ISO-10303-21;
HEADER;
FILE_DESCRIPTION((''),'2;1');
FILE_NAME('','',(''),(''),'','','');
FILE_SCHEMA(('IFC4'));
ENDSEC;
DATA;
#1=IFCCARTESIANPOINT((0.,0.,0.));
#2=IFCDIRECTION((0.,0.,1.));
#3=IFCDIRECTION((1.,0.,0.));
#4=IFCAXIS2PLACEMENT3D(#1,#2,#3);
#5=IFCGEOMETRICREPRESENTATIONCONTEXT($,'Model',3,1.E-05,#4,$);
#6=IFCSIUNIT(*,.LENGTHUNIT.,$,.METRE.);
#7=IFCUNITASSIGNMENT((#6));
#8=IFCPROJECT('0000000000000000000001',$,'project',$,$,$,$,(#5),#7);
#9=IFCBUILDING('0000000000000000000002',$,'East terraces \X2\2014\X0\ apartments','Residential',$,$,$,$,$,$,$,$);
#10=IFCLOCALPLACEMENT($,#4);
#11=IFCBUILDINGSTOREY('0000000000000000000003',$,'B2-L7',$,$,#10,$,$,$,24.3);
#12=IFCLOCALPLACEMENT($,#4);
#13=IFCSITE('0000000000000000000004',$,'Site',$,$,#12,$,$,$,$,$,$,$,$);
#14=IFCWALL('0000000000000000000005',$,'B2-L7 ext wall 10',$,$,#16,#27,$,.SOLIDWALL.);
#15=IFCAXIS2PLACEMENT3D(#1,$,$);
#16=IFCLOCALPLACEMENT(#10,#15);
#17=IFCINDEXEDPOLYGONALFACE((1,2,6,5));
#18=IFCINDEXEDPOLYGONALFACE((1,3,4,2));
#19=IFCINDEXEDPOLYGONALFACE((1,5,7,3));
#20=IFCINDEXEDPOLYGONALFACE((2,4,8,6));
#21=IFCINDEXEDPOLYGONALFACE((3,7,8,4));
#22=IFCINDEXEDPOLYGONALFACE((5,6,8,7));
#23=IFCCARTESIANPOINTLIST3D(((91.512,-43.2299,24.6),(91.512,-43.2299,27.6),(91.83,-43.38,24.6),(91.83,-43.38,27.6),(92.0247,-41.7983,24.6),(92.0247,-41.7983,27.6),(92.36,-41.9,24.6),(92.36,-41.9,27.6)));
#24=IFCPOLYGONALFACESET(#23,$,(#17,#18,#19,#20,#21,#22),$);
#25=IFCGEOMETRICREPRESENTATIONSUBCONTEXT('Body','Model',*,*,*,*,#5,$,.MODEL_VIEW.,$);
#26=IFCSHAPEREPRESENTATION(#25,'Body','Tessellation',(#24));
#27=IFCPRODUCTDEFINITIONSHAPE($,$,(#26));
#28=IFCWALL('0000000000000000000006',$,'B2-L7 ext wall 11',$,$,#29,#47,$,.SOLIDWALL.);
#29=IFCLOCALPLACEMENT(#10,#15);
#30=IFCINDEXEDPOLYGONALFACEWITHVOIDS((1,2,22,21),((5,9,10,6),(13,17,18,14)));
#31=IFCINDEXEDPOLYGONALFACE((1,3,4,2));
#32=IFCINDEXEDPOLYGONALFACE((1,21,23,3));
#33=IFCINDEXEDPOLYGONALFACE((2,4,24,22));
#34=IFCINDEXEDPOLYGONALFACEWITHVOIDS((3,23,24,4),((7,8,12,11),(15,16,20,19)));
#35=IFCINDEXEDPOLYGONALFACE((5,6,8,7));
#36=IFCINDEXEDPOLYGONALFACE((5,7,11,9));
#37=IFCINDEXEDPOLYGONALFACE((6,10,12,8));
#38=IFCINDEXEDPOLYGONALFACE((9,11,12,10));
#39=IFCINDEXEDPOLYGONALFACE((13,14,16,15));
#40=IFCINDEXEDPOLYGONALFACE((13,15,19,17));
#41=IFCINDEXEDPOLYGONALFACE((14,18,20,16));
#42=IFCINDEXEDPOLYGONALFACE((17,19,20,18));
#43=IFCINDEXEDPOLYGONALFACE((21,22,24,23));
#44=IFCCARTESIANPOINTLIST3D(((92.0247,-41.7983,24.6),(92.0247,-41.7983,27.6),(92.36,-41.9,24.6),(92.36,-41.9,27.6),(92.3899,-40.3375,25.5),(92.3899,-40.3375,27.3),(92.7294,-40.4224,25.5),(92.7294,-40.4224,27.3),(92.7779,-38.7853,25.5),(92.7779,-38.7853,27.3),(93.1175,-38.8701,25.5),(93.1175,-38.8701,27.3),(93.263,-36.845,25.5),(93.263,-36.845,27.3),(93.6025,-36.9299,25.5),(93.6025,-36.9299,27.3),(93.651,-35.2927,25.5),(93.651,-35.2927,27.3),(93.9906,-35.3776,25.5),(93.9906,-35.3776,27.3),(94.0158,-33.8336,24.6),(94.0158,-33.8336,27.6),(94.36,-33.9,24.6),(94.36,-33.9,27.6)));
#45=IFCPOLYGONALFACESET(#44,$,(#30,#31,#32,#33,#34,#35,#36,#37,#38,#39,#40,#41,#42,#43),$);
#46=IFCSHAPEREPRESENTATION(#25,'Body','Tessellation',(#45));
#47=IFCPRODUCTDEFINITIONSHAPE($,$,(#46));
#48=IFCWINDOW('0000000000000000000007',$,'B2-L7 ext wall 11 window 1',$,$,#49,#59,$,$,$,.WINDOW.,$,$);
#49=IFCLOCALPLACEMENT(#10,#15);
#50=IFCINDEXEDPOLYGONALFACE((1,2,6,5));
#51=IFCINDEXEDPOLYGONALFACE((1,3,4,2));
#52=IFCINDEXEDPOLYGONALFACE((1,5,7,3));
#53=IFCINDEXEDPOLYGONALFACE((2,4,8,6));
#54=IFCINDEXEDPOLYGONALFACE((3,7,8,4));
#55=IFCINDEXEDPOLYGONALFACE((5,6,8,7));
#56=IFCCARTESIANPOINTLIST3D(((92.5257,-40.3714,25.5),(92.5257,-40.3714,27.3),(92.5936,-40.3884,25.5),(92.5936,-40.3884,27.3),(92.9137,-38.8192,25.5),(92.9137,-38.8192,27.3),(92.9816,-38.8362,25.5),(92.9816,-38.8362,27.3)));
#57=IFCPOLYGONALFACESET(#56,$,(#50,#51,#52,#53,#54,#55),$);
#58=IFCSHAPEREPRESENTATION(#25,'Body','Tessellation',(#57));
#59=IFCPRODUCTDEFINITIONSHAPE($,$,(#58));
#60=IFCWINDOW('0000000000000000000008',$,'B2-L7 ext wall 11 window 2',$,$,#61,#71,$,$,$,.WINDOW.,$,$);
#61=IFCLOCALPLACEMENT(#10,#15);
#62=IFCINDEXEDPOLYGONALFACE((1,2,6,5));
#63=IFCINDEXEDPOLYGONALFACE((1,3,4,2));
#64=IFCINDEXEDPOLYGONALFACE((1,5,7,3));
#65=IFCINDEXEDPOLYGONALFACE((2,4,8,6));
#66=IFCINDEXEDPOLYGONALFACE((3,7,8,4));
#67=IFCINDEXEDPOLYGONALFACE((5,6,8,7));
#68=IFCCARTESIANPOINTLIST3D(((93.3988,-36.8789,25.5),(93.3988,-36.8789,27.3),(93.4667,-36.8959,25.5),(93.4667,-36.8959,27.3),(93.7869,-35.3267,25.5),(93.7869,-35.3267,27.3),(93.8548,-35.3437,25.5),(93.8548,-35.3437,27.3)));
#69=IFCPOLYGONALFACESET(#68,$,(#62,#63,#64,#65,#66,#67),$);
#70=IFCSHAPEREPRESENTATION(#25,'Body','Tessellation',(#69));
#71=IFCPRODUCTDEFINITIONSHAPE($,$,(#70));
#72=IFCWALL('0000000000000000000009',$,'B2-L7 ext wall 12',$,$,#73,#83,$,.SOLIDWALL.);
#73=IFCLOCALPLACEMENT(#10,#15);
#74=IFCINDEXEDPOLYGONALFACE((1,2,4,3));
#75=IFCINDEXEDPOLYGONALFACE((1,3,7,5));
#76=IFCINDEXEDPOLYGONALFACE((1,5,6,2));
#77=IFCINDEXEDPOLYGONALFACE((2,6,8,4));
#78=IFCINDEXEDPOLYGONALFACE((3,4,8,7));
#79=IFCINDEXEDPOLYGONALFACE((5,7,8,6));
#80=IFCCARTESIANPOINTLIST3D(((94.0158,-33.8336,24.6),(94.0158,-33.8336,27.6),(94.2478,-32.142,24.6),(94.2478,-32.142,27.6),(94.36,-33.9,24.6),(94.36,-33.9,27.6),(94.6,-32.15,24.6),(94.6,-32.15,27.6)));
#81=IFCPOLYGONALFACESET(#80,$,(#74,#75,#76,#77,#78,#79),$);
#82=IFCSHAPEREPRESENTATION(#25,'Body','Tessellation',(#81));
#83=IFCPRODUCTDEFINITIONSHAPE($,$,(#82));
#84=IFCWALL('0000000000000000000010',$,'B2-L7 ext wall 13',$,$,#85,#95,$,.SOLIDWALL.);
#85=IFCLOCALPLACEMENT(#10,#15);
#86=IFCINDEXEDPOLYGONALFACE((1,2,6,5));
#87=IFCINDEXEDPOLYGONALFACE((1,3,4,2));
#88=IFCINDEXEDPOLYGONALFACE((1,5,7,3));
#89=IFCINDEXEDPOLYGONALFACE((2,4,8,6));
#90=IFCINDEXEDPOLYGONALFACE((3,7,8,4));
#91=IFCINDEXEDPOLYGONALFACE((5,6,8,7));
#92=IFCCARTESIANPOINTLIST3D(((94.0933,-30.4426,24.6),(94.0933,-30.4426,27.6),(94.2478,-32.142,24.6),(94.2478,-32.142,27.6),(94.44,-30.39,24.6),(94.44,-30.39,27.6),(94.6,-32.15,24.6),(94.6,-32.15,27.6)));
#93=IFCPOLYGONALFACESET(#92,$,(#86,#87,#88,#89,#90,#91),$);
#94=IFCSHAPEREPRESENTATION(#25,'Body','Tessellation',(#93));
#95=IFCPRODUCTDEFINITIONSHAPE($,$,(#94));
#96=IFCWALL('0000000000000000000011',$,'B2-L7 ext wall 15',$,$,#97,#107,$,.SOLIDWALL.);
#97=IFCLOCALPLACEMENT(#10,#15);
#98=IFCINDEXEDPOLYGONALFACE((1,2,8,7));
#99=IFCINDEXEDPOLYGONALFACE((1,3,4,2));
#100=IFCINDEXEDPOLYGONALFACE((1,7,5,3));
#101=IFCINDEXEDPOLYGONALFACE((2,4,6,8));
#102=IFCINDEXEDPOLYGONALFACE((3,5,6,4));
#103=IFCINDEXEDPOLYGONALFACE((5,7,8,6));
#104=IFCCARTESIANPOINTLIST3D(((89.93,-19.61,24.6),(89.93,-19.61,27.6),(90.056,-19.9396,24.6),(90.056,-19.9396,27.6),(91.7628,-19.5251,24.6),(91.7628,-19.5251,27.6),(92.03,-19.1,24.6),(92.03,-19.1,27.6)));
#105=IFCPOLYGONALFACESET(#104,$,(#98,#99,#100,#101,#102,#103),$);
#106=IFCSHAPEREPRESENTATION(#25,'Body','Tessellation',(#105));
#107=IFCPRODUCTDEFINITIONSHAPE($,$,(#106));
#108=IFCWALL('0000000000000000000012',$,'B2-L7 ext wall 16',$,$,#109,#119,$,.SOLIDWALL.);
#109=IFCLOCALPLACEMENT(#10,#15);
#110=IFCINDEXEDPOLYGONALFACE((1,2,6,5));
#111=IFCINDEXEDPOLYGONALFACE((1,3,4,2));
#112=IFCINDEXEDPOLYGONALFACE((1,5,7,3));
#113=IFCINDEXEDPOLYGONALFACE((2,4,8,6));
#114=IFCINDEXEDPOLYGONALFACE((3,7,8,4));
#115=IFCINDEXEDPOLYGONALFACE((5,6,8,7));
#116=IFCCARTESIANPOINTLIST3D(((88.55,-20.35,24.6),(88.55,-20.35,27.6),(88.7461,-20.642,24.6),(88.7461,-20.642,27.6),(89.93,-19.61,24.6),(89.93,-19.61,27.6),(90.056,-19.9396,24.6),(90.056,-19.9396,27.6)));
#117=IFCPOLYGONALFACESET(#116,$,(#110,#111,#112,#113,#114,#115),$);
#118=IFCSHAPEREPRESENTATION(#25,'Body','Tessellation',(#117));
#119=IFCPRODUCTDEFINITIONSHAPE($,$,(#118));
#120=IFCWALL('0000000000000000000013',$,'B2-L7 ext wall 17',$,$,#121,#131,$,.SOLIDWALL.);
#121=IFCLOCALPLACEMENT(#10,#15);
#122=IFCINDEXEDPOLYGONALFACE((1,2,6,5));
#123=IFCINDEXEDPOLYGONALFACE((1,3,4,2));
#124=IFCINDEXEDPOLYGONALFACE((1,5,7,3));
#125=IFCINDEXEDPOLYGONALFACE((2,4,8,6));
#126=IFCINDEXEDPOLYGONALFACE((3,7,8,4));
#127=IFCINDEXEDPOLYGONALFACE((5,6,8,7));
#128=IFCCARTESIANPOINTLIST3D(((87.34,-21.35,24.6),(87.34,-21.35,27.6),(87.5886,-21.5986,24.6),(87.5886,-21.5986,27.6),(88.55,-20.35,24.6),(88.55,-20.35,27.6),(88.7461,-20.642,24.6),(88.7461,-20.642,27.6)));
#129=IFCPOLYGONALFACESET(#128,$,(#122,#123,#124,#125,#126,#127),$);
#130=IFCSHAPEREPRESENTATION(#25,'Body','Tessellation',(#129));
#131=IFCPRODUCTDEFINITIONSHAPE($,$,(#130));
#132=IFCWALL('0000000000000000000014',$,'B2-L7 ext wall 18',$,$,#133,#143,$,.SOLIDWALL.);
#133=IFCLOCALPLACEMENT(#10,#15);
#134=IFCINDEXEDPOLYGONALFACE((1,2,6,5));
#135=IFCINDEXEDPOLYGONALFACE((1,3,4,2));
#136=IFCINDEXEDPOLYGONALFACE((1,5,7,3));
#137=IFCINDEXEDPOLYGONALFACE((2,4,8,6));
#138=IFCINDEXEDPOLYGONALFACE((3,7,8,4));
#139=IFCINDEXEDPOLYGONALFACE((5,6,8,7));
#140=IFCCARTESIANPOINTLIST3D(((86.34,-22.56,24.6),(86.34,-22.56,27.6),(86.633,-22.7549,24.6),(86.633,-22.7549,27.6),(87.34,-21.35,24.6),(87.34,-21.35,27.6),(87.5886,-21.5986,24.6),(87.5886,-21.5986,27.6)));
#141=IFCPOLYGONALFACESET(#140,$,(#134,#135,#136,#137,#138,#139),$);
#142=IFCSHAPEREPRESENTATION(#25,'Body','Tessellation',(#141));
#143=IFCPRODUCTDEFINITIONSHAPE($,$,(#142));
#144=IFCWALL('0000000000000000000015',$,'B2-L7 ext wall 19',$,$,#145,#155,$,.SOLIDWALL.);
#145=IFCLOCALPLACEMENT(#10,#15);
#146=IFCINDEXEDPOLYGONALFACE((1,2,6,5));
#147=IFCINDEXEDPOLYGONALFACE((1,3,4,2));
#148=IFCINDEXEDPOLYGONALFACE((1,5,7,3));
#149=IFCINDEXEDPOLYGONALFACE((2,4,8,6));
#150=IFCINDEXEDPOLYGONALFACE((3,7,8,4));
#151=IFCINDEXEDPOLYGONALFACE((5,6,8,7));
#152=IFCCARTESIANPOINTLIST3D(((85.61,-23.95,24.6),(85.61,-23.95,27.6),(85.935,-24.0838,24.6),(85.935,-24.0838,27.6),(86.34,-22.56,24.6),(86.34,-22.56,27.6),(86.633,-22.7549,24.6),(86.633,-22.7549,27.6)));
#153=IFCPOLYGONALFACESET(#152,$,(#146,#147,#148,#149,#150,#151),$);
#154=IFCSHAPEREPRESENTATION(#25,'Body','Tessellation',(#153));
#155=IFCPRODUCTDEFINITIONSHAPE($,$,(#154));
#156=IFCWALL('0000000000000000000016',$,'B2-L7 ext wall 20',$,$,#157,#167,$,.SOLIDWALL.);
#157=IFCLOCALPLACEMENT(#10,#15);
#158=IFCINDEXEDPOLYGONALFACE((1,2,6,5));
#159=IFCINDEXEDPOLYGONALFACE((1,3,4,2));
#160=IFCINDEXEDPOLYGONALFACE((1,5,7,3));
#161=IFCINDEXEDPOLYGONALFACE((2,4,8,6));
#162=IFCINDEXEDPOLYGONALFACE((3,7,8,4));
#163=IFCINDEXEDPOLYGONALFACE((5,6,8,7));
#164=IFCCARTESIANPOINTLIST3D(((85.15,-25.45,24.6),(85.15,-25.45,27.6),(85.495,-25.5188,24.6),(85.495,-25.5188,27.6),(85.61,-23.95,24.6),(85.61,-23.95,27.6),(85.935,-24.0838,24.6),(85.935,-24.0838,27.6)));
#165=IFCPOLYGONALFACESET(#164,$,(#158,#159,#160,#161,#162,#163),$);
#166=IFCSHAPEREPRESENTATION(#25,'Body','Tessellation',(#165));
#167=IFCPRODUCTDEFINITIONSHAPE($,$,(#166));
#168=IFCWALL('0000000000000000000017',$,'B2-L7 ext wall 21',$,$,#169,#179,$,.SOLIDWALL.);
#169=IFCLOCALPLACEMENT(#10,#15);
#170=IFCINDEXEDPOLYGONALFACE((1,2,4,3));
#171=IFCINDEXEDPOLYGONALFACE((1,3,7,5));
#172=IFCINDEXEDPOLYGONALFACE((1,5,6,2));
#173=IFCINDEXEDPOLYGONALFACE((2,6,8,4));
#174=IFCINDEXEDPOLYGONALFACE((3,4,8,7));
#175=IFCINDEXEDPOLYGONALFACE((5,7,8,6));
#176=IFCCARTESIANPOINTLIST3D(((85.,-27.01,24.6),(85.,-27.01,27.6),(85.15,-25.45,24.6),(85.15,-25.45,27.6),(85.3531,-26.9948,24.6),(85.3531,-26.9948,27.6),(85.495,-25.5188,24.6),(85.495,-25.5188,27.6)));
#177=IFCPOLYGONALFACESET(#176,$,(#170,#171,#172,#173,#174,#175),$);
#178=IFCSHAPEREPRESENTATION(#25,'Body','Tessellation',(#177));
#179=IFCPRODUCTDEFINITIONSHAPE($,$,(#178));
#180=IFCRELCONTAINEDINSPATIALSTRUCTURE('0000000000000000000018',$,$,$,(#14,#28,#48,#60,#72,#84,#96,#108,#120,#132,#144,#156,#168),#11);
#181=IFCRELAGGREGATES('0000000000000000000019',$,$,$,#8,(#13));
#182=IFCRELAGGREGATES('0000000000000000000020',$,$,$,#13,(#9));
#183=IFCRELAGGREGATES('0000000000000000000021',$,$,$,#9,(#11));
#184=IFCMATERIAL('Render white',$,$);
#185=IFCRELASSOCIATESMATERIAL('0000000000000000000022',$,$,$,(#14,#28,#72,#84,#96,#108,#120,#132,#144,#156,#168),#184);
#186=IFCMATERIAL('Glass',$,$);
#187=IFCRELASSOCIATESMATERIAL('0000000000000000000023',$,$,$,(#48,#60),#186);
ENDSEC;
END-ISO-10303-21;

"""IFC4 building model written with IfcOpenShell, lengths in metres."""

from ifc_helpers import new_model, si_unit, frame, origin_with_axes, place, context, subcontext, project, spatial, polyline, outline, extrude, material, element, fill, save


model = new_model("IFC4")

# Units and contexts
model_context = context("Model", 3, precision=1e-05, world=origin_with_axes())
body_context = subcontext(model_context, "Body", "Model", "MODEL_VIEW")
ifc_project = project(units=[si_unit("LENGTHUNIT", "METRE")], contexts=[model_context])

# Site, building, storey
site_placement = place(None, origin_with_axes())
site = spatial("IfcSite", under=ifc_project, at=site_placement, Name="Site")
building = spatial("IfcBuilding", under=site, Name="East terraces — apartments", Description="Residential")
storey_placement = place(None, origin_with_axes())
storey = spatial("IfcBuildingStorey", under=building, at=storey_placement, Name="B2-L7", Elevation=24.3)

# Wall
ifc_material_1 = material(Name="Render white")
wall_1_placement = place(storey_placement, origin_with_axes())
element("IfcWall", 1, at=wall_1_placement, inside=storey, material=ifc_material_1, Name="B2-L7 ext wall 10", PredefinedType="SOLIDWALL", context=body_context, shape_type="SweptSolid", body=[
    extrude(outline(polyline([(91.83, -43.38), (92.36, -41.9), (92.0247, -41.7983), (91.512, -43.2299), (91.83, -43.38)])), frame((0.0, 0.0, 24.6), z_axis=(0.0, 0.0, 1.0), x_axis=(1.0, 0.0, 0.0)), (0.0, 0.0, 1.0), 3.0),
])

# Wall, openings, windows
wall_2_placement = place(storey_placement, origin_with_axes())
wall_2 = element("IfcWall", 2, at=wall_2_placement, inside=storey, material=ifc_material_1, Name="B2-L7 ext wall 11", PredefinedType="SOLIDWALL", context=body_context, shape_type="SweptSolid", body=[
    extrude(outline(polyline([(92.36, -41.9), (94.36, -33.9), (94.0158, -33.8336), (92.0247, -41.7983), (92.36, -41.9)])), frame((0.0, 0.0, 24.6), z_axis=(0.0, 0.0, 1.0), x_axis=(1.0, 0.0, 0.0)), (0.0, 0.0, 1.0), 3.0),
])
opening_1_placement = place(wall_2_placement, origin_with_axes())
opening_1 = element("IfcOpeningElement", 3, at=opening_1_placement, cuts=wall_2, context=body_context, shape_type="SweptSolid", body=[
    extrude(outline(polyline([(92.7779, -40.4345), (93.166, -38.8823), (92.7294, -38.7731), (92.3414, -40.3254), (92.7779, -40.4345)])), frame((0.0, 0.0, 25.5), z_axis=(0.0, 0.0, 1.0), x_axis=(1.0, 0.0, 0.0)), (0.0, 0.0, 1.0), 1.8),
])
opening_2_placement = place(wall_2_placement, origin_with_axes())
opening_2 = element("IfcOpeningElement", 4, at=opening_2_placement, cuts=wall_2, context=body_context, shape_type="SweptSolid", body=[
    extrude(outline(polyline([(93.651, -36.942), (94.0391, -35.3898), (93.6025, -35.2806), (93.2145, -36.8328), (93.651, -36.942)])), frame((0.0, 0.0, 25.5), z_axis=(0.0, 0.0, 1.0), x_axis=(1.0, 0.0, 0.0)), (0.0, 0.0, 1.0), 1.8),
])
ifc_material_2 = material(Name="Glass")
window_1_placement = place(storey_placement, origin_with_axes())
window_1 = element("IfcWindow", 5, at=window_1_placement, inside=storey, material=ifc_material_2, Name="B2-L7 ext wall 11 window 1", PredefinedType="WINDOW", context=body_context, shape_type="SweptSolid", body=[
    extrude(outline(polyline([(92.5936, -40.3884), (92.9816, -38.8362), (92.9137, -38.8192), (92.5257, -40.3714), (92.5936, -40.3884)])), frame((0.0, 0.0, 25.5), z_axis=(0.0, 0.0, 1.0), x_axis=(1.0, 0.0, 0.0)), (0.0, 0.0, 1.0), 1.8),
])
fill(opening_1, window_1)
window_2_placement = place(storey_placement, origin_with_axes())
window_2 = element("IfcWindow", 6, at=window_2_placement, inside=storey, material=ifc_material_2, Name="B2-L7 ext wall 11 window 2", PredefinedType="WINDOW", context=body_context, shape_type="SweptSolid", body=[
    extrude(outline(polyline([(93.4667, -36.8959), (93.8548, -35.3437), (93.7869, -35.3267), (93.3988, -36.8789), (93.4667, -36.8959)])), frame((0.0, 0.0, 25.5), z_axis=(0.0, 0.0, 1.0), x_axis=(1.0, 0.0, 0.0)), (0.0, 0.0, 1.0), 1.8),
])
fill(opening_2, window_2)

# Walls
wall_3_placement = place(storey_placement, origin_with_axes())
element("IfcWall", 7, at=wall_3_placement, inside=storey, material=ifc_material_1, Name="B2-L7 ext wall 12", PredefinedType="SOLIDWALL", context=body_context, shape_type="SweptSolid", body=[
    extrude(outline(polyline([(94.36, -33.9), (94.6, -32.15), (94.2478, -32.142), (94.0158, -33.8336), (94.36, -33.9)])), frame((0.0, 0.0, 24.6), z_axis=(0.0, 0.0, 1.0), x_axis=(1.0, 0.0, 0.0)), (0.0, 0.0, 1.0), 3.0),
])
wall_4_placement = place(storey_placement, origin_with_axes())
element("IfcWall", 8, at=wall_4_placement, inside=storey, material=ifc_material_1, Name="B2-L7 ext wall 13", PredefinedType="SOLIDWALL", context=body_context, shape_type="SweptSolid", body=[
    extrude(outline(polyline([(94.6, -32.15), (94.44, -30.39), (94.0933, -30.4426), (94.2478, -32.142), (94.6, -32.15)])), frame((0.0, 0.0, 24.6), z_axis=(0.0, 0.0, 1.0), x_axis=(1.0, 0.0, 0.0)), (0.0, 0.0, 1.0), 3.0),
])

# Walls
wall_5_placement = place(storey_placement, origin_with_axes())
element("IfcWall", 9, at=wall_5_placement, inside=storey, material=ifc_material_1, Name="B2-L7 ext wall 15", PredefinedType="SOLIDWALL", context=body_context, shape_type="SweptSolid", body=[
    extrude(outline(polyline([(92.03, -19.1), (89.93, -19.61), (90.056, -19.9396), (91.7628, -19.5251), (92.03, -19.1)])), frame((0.0, 0.0, 24.6), z_axis=(0.0, 0.0, 1.0), x_axis=(1.0, 0.0, 0.0)), (0.0, 0.0, 1.0), 3.0),
])
wall_6_placement = place(storey_placement, origin_with_axes())
element("IfcWall", 10, at=wall_6_placement, inside=storey, material=ifc_material_1, Name="B2-L7 ext wall 16", PredefinedType="SOLIDWALL", context=body_context, shape_type="SweptSolid", body=[
    extrude(outline(polyline([(89.93, -19.61), (88.55, -20.35), (88.7461, -20.642), (90.056, -19.9396), (89.93, -19.61)])), frame((0.0, 0.0, 24.6), z_axis=(0.0, 0.0, 1.0), x_axis=(1.0, 0.0, 0.0)), (0.0, 0.0, 1.0), 3.0),
])
wall_7_placement = place(storey_placement, origin_with_axes())
element("IfcWall", 11, at=wall_7_placement, inside=storey, material=ifc_material_1, Name="B2-L7 ext wall 17", PredefinedType="SOLIDWALL", context=body_context, shape_type="SweptSolid", body=[
    extrude(outline(polyline([(88.55, -20.35), (87.34, -21.35), (87.5886, -21.5986), (88.7461, -20.642), (88.55, -20.35)])), frame((0.0, 0.0, 24.6), z_axis=(0.0, 0.0, 1.0), x_axis=(1.0, 0.0, 0.0)), (0.0, 0.0, 1.0), 3.0),
])
wall_8_placement = place(storey_placement, origin_with_axes())
element("IfcWall", 12, at=wall_8_placement, inside=storey, material=ifc_material_1, Name="B2-L7 ext wall 18", PredefinedType="SOLIDWALL", context=body_context, shape_type="SweptSolid", body=[
    extrude(outline(polyline([(87.34, -21.35), (86.34, -22.56), (86.633, -22.7549), (87.5886, -21.5986), (87.34, -21.35)])), frame((0.0, 0.0, 24.6), z_axis=(0.0, 0.0, 1.0), x_axis=(1.0, 0.0, 0.0)), (0.0, 0.0, 1.0), 3.0),
])
wall_9_placement = place(storey_placement, origin_with_axes())
element("IfcWall", 13, at=wall_9_placement, inside=storey, material=ifc_material_1, Name="B2-L7 ext wall 19", PredefinedType="SOLIDWALL", context=body_context, shape_type="SweptSolid", body=[
    extrude(outline(polyline([(86.34, -22.56), (85.61, -23.95), (85.935, -24.0838), (86.633, -22.7549), (86.34, -22.56)])), frame((0.0, 0.0, 24.6), z_axis=(0.0, 0.0, 1.0), x_axis=(1.0, 0.0, 0.0)), (0.0, 0.0, 1.0), 3.0),
])
wall_10_placement = place(storey_placement, origin_with_axes())
element("IfcWall", 14, at=wall_10_placement, inside=storey, material=ifc_material_1, Name="B2-L7 ext wall 20", PredefinedType="SOLIDWALL", context=body_context, shape_type="SweptSolid", body=[
    extrude(outline(polyline([(85.61, -23.95), (85.15, -25.45), (85.495, -25.5188), (85.935, -24.0838), (85.61, -23.95)])), frame((0.0, 0.0, 24.6), z_axis=(0.0, 0.0, 1.0), x_axis=(1.0, 0.0, 0.0)), (0.0, 0.0, 1.0), 3.0),
])
wall_11_placement = place(storey_placement, origin_with_axes())
element("IfcWall", 15, at=wall_11_placement, inside=storey, material=ifc_material_1, Name="B2-L7 ext wall 21", PredefinedType="SOLIDWALL", context=body_context, shape_type="SweptSolid", body=[
    extrude(outline(polyline([(85.15, -25.45), (85.0, -27.01), (85.3531, -26.9948), (85.495, -25.5188), (85.15, -25.45)])), frame((0.0, 0.0, 24.6), z_axis=(0.0, 0.0, 1.0), x_axis=(1.0, 0.0, 0.0)), (0.0, 0.0, 1.0), 3.0),
])

save(model, "model.ifc")
